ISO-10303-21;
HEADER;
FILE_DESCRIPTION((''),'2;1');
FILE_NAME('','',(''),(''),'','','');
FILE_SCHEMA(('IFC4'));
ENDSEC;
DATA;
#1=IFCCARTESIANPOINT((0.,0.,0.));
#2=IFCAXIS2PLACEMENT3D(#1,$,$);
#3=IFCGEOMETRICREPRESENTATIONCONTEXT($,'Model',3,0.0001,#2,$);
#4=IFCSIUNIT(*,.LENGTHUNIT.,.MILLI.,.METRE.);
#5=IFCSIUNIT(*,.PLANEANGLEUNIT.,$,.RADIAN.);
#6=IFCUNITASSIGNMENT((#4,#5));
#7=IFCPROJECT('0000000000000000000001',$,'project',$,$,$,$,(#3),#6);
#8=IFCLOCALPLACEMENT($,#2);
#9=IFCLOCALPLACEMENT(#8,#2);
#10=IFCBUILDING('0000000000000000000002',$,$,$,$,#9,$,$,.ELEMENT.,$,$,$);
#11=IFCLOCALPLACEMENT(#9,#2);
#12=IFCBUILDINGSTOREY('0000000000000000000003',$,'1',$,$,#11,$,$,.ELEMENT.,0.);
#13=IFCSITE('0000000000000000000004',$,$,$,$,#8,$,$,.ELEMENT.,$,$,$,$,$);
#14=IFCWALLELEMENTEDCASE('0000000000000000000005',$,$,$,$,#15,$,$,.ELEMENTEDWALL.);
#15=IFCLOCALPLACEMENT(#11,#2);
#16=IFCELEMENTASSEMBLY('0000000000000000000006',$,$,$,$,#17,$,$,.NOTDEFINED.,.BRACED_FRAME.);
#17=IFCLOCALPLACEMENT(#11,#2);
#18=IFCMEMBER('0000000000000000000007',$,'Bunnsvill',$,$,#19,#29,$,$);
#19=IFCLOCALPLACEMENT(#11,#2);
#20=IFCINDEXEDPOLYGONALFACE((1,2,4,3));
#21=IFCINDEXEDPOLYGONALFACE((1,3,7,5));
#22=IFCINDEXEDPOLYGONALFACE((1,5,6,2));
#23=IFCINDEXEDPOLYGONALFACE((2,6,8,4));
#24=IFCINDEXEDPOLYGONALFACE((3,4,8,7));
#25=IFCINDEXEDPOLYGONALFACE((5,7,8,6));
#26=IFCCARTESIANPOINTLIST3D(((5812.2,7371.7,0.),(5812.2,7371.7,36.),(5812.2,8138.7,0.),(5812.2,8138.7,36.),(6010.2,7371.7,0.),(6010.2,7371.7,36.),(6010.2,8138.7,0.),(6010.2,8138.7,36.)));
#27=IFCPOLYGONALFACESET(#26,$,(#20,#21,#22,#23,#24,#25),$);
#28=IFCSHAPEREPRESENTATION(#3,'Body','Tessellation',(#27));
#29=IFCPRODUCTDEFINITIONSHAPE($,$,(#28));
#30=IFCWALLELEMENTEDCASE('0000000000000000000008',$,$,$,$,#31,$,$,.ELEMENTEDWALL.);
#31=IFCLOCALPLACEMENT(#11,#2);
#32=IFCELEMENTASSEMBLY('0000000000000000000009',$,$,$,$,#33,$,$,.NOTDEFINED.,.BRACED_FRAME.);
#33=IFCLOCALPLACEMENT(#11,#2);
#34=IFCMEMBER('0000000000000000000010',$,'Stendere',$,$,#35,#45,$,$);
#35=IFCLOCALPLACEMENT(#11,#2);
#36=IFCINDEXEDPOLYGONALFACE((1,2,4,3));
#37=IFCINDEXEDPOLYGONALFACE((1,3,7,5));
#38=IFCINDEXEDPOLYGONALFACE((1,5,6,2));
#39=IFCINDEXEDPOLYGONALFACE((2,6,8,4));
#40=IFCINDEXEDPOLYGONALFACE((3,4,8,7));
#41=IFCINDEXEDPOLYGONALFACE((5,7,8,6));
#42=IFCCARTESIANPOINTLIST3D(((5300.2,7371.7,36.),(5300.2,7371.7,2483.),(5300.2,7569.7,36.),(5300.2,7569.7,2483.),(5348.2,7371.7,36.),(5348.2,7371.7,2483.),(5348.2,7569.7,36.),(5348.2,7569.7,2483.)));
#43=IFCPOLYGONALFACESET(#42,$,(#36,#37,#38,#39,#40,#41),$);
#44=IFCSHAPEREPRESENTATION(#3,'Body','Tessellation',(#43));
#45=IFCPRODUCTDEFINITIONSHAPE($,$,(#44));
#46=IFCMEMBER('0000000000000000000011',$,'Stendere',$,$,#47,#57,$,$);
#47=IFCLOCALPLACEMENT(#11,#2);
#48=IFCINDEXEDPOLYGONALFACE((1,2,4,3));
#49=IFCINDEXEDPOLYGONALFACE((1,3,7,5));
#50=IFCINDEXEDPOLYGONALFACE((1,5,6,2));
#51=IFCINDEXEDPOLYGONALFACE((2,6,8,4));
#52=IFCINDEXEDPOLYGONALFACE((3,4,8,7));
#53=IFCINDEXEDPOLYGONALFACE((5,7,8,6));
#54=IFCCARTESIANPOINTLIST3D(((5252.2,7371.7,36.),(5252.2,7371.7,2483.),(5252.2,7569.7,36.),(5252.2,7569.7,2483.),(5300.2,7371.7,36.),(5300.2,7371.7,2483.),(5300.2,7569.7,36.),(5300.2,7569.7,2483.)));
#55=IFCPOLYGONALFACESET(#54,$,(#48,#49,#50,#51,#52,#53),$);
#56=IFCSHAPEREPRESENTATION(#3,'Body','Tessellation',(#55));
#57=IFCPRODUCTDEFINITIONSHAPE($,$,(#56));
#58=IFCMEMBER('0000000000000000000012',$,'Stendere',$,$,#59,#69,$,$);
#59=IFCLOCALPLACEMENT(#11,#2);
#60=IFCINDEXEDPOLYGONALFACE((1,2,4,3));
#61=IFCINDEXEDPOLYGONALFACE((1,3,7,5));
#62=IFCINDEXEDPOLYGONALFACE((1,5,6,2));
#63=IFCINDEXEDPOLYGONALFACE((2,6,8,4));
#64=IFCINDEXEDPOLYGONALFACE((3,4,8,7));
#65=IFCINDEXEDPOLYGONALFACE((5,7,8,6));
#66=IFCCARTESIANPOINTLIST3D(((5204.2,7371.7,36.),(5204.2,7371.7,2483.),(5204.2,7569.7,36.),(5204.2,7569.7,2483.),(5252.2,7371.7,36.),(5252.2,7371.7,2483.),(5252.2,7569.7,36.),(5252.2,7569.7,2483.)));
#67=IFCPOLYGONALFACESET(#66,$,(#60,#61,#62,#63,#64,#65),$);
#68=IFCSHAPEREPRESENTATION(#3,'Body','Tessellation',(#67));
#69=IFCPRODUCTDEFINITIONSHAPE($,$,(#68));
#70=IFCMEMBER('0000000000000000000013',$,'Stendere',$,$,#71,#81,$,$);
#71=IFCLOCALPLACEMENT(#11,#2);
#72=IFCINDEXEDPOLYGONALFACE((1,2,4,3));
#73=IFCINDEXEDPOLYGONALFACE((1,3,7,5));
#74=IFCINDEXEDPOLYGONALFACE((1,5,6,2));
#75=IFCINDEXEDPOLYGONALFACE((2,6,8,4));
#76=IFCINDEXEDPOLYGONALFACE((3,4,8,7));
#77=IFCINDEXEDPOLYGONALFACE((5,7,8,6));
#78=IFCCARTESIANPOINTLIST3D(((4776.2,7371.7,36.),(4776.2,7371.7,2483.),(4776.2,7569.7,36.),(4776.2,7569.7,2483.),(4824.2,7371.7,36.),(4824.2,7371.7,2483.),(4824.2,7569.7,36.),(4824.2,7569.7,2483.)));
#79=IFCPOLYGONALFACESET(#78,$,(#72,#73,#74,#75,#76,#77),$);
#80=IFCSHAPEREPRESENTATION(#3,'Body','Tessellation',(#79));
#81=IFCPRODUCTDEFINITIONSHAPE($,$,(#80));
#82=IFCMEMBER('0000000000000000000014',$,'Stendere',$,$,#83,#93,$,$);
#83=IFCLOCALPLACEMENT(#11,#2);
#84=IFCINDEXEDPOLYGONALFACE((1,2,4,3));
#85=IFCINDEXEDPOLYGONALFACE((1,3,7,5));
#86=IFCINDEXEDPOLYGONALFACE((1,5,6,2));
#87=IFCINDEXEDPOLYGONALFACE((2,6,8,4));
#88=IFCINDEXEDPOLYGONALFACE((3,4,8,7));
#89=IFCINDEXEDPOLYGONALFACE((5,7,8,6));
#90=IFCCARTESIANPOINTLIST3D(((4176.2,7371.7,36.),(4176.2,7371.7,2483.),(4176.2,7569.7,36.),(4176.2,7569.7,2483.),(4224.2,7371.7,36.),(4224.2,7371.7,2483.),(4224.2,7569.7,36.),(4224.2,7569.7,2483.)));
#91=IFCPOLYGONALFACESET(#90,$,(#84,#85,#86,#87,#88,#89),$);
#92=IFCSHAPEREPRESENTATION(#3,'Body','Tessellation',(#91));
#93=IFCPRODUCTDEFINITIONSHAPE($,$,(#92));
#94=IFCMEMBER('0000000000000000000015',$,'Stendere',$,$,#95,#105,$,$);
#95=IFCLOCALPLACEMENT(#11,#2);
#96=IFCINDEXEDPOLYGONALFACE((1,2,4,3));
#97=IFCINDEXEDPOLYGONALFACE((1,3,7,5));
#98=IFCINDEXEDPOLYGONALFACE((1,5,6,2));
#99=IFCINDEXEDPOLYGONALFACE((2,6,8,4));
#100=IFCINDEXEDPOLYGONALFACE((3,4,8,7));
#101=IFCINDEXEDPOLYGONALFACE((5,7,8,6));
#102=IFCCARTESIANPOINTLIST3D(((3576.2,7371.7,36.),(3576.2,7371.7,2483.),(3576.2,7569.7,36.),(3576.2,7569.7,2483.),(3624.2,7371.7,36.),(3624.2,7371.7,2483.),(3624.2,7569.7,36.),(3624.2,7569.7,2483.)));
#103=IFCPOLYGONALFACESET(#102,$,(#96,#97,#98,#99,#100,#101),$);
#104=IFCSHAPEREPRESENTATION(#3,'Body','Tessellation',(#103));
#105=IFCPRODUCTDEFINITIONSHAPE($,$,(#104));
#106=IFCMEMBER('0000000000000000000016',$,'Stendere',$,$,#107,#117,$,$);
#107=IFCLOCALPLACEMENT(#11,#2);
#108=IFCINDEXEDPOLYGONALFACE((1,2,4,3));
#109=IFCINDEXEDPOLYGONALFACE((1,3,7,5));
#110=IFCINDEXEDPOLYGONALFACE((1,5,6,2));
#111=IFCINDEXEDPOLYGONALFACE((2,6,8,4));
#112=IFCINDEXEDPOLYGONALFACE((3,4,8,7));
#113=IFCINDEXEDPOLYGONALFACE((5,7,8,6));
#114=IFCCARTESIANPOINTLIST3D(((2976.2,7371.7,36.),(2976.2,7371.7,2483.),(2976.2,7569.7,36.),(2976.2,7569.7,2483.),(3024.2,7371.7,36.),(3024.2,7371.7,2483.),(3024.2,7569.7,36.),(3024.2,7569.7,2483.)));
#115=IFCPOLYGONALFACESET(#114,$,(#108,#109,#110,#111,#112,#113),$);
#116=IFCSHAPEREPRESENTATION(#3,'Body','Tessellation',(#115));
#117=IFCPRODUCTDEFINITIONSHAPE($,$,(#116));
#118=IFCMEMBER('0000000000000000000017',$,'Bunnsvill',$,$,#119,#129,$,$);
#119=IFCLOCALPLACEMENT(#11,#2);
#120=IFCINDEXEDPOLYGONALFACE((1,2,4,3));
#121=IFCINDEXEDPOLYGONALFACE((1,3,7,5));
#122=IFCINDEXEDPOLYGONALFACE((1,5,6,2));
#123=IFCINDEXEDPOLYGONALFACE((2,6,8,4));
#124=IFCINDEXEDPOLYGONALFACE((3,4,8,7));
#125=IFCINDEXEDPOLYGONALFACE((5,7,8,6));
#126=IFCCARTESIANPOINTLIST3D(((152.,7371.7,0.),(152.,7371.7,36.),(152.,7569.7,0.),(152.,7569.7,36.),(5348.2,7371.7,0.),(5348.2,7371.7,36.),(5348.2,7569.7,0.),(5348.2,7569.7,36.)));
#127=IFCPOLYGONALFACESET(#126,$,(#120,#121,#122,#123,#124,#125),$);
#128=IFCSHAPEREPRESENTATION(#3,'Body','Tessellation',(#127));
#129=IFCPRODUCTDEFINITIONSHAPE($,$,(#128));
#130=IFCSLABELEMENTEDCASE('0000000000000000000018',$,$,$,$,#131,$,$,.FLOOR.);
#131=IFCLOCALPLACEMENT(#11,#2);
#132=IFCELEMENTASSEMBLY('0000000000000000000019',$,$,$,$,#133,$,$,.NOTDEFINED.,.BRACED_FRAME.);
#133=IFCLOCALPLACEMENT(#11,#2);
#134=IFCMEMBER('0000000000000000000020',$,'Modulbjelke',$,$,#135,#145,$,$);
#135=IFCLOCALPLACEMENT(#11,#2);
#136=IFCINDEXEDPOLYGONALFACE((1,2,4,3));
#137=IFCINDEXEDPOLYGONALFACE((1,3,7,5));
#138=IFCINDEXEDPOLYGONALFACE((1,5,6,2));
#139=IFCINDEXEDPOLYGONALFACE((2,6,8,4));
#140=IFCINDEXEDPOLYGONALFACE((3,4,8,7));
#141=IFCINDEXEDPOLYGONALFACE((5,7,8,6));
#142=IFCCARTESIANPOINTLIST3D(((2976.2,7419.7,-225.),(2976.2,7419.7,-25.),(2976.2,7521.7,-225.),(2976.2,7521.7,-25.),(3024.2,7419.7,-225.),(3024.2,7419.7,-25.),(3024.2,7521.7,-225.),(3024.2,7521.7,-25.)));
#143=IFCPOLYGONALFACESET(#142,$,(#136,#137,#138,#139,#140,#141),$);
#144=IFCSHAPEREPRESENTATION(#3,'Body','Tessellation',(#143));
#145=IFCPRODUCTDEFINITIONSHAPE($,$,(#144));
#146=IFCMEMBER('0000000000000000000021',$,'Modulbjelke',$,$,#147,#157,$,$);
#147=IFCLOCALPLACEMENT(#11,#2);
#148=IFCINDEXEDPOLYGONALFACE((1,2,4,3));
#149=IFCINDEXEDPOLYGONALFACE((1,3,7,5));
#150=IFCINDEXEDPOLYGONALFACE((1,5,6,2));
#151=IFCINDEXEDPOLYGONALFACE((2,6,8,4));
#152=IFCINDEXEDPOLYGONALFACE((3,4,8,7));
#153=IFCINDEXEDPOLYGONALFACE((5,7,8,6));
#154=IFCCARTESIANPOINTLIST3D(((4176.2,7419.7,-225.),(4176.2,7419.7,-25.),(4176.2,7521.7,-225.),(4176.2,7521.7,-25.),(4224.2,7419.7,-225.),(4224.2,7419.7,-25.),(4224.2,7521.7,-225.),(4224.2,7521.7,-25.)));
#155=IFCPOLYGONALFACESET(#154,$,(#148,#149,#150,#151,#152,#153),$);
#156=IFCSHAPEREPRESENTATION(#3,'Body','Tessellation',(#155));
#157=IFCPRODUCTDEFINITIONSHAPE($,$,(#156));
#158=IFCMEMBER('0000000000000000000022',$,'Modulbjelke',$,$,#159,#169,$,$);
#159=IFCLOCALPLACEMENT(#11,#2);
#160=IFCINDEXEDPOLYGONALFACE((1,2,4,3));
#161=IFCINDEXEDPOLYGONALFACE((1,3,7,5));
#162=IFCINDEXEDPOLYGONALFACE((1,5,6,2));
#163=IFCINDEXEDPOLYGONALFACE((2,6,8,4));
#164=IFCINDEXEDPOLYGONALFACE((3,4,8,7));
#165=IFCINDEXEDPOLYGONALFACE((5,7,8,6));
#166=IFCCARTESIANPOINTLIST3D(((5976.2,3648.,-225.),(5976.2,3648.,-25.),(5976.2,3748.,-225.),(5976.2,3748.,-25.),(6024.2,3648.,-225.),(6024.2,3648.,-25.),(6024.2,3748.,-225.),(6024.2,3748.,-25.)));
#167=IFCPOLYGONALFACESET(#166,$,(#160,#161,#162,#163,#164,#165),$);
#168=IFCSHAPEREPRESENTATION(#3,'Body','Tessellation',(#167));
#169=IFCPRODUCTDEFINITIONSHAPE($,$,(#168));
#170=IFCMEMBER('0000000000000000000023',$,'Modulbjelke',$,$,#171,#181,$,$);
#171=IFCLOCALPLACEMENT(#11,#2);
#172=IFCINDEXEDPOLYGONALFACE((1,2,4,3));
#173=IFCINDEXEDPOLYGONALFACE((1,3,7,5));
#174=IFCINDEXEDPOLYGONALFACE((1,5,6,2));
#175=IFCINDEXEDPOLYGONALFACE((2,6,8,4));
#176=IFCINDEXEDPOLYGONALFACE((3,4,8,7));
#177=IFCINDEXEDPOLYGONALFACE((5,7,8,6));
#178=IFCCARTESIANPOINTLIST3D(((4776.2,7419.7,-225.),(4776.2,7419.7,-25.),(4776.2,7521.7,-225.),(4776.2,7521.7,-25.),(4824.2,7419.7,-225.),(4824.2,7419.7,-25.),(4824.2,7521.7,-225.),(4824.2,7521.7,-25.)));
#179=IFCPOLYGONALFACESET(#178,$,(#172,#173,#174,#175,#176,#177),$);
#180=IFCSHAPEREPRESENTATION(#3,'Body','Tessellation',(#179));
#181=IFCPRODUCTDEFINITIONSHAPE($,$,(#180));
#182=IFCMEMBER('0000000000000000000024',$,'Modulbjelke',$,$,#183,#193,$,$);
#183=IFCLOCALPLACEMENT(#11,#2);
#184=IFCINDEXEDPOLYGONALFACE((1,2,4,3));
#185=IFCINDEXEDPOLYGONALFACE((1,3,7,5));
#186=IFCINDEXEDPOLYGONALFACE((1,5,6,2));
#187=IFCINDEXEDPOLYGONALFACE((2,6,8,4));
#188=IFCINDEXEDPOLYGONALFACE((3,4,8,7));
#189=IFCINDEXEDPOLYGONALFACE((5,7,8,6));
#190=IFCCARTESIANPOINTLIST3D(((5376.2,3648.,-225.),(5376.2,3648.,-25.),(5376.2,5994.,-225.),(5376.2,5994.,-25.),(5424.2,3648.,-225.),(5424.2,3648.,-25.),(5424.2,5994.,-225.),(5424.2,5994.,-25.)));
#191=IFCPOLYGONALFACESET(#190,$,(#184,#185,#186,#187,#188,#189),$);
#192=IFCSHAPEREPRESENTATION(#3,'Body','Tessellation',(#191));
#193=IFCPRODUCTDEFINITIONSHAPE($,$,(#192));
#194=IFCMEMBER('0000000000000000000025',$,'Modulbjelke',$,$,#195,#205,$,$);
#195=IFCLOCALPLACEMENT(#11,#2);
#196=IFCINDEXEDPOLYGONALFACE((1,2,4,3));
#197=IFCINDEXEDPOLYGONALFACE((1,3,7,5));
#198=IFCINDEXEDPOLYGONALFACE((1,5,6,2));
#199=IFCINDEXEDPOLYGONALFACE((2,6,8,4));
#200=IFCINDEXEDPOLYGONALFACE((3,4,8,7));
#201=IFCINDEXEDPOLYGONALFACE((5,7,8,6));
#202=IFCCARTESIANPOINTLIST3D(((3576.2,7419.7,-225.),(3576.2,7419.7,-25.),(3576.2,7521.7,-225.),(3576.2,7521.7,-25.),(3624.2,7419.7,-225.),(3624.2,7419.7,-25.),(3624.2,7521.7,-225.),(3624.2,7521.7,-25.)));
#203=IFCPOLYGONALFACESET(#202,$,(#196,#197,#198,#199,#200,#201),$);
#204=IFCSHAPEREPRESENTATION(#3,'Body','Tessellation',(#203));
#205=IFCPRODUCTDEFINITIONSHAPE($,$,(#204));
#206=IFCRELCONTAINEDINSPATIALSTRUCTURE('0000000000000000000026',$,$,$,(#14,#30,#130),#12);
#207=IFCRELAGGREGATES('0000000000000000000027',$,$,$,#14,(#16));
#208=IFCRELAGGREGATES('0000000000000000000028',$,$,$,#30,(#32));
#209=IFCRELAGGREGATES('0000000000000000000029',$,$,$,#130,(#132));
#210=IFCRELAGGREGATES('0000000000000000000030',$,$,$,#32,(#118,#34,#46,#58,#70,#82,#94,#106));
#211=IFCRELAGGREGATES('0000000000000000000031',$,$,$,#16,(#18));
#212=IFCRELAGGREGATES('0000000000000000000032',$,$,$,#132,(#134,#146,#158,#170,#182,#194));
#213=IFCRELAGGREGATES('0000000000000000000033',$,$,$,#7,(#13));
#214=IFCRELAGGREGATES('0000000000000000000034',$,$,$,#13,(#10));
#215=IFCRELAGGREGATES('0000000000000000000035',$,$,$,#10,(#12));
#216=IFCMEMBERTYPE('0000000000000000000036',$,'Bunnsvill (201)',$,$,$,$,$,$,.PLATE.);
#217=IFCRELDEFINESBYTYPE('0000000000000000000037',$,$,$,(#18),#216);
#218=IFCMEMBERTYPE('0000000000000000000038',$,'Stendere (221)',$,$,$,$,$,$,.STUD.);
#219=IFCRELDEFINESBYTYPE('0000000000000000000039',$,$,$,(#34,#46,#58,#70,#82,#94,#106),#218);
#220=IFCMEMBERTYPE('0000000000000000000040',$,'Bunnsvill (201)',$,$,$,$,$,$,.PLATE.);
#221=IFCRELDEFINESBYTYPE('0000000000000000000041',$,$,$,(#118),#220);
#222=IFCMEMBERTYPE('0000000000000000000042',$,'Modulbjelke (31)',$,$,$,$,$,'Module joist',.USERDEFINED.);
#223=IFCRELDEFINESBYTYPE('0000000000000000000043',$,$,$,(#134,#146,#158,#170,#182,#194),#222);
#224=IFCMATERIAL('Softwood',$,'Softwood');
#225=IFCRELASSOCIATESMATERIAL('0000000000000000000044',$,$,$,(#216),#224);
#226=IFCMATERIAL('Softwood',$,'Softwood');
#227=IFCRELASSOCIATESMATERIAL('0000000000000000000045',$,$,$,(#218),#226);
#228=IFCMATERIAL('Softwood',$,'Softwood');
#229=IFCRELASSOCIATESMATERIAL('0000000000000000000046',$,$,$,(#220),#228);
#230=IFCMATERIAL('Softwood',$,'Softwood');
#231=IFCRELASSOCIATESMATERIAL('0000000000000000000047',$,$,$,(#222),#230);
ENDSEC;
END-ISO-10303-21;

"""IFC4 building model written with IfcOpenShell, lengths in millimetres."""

from ifc_helpers import new_model, si_unit, frame, origin, place, context, project, spatial, rectangle, extrude, clip, halfspace, material, material_profile, profile_set, type_object, element, aggregate, save


model = new_model("IFC4")

# Units and contexts
model_context = context("Model", 3, precision=0.0001, world=origin())
ifc_project = project(units=[si_unit("LENGTHUNIT", "METRE", prefix="MILLI"), si_unit("PLANEANGLEUNIT", "RADIAN")], contexts=[model_context])

# Site, building, storey
site_placement = place(None, origin())
site = spatial("IfcSite", under=ifc_project, at=site_placement, CompositionType="ELEMENT")
building_placement = place(site_placement, origin())
building = spatial("IfcBuilding", under=site, at=building_placement, CompositionType="ELEMENT")
storey_placement = place(building_placement, origin())
storey = spatial("IfcBuildingStorey", under=building, at=storey_placement, Name="1", CompositionType="ELEMENT", Elevation=0.0)

# Wall, element assembly, member
wall_1_placement = place(storey_placement, frame((6010.2, 8138.7, 0.0), z_axis=(-1.0, 0.0, 0.0), x_axis=(0.0, -1.0, 0.0)))
wall_1 = element("IfcWallElementedCase", 1, at=wall_1_placement, inside=storey, PredefinedType="ELEMENTEDWALL")
assembly_1_placement = place(wall_1_placement, origin())
assembly_1 = element("IfcElementAssembly", 2, at=assembly_1_placement, AssemblyPlace="NOTDEFINED", PredefinedType="BRACED_FRAME")
aggregate(wall_1, [assembly_1])
ifc_material_1 = material(Name="Softwood", Category="Softwood")
ifc_material_profile_1 = material_profile(ifc_material_1, rectangle(XDim=36.0, YDim=198.0), Name="Bunnsvill (201)")
ifc_profile_set_1 = profile_set([ifc_material_profile_1])
member_type_1 = type_object("IfcMemberType", Name="Bunnsvill (201)", PredefinedType="PLATE", material=ifc_profile_set_1)
member_1_placement = place(assembly_1_placement, frame((0.0, 18.0, 0.0), z_axis=(1.0, 0.0, 0.0), x_axis=(0.0, 1.0, 0.0)))
member_1 = element("IfcMember", 3, at=member_1_placement, type_object=member_type_1, Name="Bunnsvill", context=model_context, shape_type="SweptSolid", body=[
    extrude(rectangle(XDim=36.0, YDim=198.0), frame((0.0, 99.0, 0.0)), (0.0, 0.0, 1.0), 767.0),
])

# Wall, element assembly, members
wall_2_placement = place(storey_placement, frame((5348.2, 7371.7, 0.0), z_axis=(0.0, 1.0, 0.0), x_axis=(-1.0, 0.0, 0.0)))
wall_2 = element("IfcWallElementedCase", 4, at=wall_2_placement, inside=storey, PredefinedType="ELEMENTEDWALL")
assembly_2_placement = place(wall_2_placement, origin())
assembly_2 = element("IfcElementAssembly", 5, at=assembly_2_placement, AssemblyPlace="NOTDEFINED", PredefinedType="BRACED_FRAME")
aggregate(wall_2, [assembly_2])
ifc_material_2 = material(Name="Softwood", Category="Softwood")
ifc_material_profile_2 = material_profile(ifc_material_2, rectangle(XDim=48.0, YDim=198.0), Name="Stendere (221)")
ifc_profile_set_2 = profile_set([ifc_material_profile_2])
member_type_2 = type_object("IfcMemberType", Name="Stendere (221)", PredefinedType="STUD", material=ifc_profile_set_2)
member_2_placement = place(assembly_2_placement, frame((24.0, 36.0, 0.0), z_axis=(0.0, 1.0, 0.0), x_axis=(-1.0, 0.0, 0.0)))
member_2 = element("IfcMember", 6, at=member_2_placement, type_object=member_type_2, Name="Stendere", context=model_context, shape_type="SweptSolid", body=[
    extrude(rectangle(XDim=48.0, YDim=198.0), frame((0.0, 99.0, 0.0)), (0.0, 0.0, 1.0), 2447.0),
])
member_3_placement = place(assembly_2_placement, frame((72.0, 36.0, 0.0), z_axis=(0.0, 1.0, 0.0), x_axis=(-1.0, 0.0, 0.0)))
member_3 = element("IfcMember", 7, at=member_3_placement, type_object=member_type_2, Name="Stendere", context=model_context, shape_type="SweptSolid", body=[
    extrude(rectangle(XDim=48.0, YDim=198.0), frame((0.0, 99.0, 0.0)), (0.0, 0.0, 1.0), 2447.0),
])
member_4_placement = place(assembly_2_placement, frame((120.0, 36.0, 0.0), z_axis=(0.0, 1.0, 0.0), x_axis=(-1.0, 0.0, 0.0)))
member_4 = element("IfcMember", 8, at=member_4_placement, type_object=member_type_2, Name="Stendere", context=model_context, shape_type="SweptSolid", body=[
    extrude(rectangle(XDim=48.0, YDim=198.0), frame((0.0, 99.0, 0.0)), (0.0, 0.0, 1.0), 2447.0),
])
member_5_placement = place(assembly_2_placement, frame((548.0, 36.0, 0.0), z_axis=(0.0, 1.0, 0.0), x_axis=(-1.0, 0.0, 0.0)))
member_5 = element("IfcMember", 9, at=member_5_placement, type_object=member_type_2, Name="Stendere", context=model_context, shape_type="SweptSolid", body=[
    extrude(rectangle(XDim=48.0, YDim=198.0), frame((0.0, 99.0, 0.0)), (0.0, 0.0, 1.0), 2447.0),
])
member_6_placement = place(assembly_2_placement, frame((1148.0, 36.0, 0.0), z_axis=(0.0, 1.0, 0.0), x_axis=(-1.0, 0.0, 0.0)))
member_6 = element("IfcMember", 10, at=member_6_placement, type_object=member_type_2, Name="Stendere", context=model_context, shape_type="SweptSolid", body=[
    extrude(rectangle(XDim=48.0, YDim=198.0), frame((0.0, 99.0, 0.0)), (0.0, 0.0, 1.0), 2447.0),
])
member_7_placement = place(assembly_2_placement, frame((1748.0, 36.0, 0.0), z_axis=(0.0, 1.0, 0.0), x_axis=(-1.0, 0.0, 0.0)))
member_7 = element("IfcMember", 11, at=member_7_placement, type_object=member_type_2, Name="Stendere", context=model_context, shape_type="SweptSolid", body=[
    extrude(rectangle(XDim=48.0, YDim=198.0), frame((0.0, 99.0, 0.0)), (0.0, 0.0, 1.0), 2447.0),
])
member_8_placement = place(assembly_2_placement, frame((2348.0, 36.0, 0.0), z_axis=(0.0, 1.0, 0.0), x_axis=(-1.0, 0.0, 0.0)))
member_8 = element("IfcMember", 12, at=member_8_placement, type_object=member_type_2, Name="Stendere", context=model_context, shape_type="SweptSolid", body=[
    extrude(rectangle(XDim=48.0, YDim=198.0), frame((0.0, 99.0, 0.0)), (0.0, 0.0, 1.0), 2447.0),
])
ifc_material_3 = material(Name="Softwood", Category="Softwood")
ifc_material_profile_3 = material_profile(ifc_material_3, rectangle(XDim=36.0, YDim=198.0), Name="Bunnsvill (201)")
ifc_profile_set_3 = profile_set([ifc_material_profile_3])
member_type_3 = type_object("IfcMemberType", Name="Bunnsvill (201)", PredefinedType="PLATE", material=ifc_profile_set_3)
member_9_placement = place(assembly_2_placement, frame((0.0, 18.0, 0.0), z_axis=(1.0, 0.0, 0.0), x_axis=(0.0, 1.0, 0.0)))
member_9 = element("IfcMember", 13, at=member_9_placement, type_object=member_type_3, Name="Bunnsvill", context=model_context, shape_type="SweptSolid", body=[
    extrude(rectangle(XDim=36.0, YDim=198.0), frame((0.0, 99.0, 0.0)), (0.0, 0.0, 1.0), 5196.2),
])

# Slab, element assembly, members
slab_placement = place(storey_placement, origin())
slab = element("IfcSlabElementedCase", 14, at=slab_placement, inside=storey, PredefinedType="FLOOR")
assembly_3_placement = place(slab_placement, frame((0.0, 0.0, -225.0)))
assembly_3 = element("IfcElementAssembly", 15, at=assembly_3_placement, AssemblyPlace="NOTDEFINED", PredefinedType="BRACED_FRAME")
aggregate(slab, [assembly_3])
ifc_material_4 = material(Name="Softwood", Category="Softwood")
ifc_material_profile_4 = material_profile(ifc_material_4, rectangle(XDim=48.0, YDim=200.0), Name="Modulbjelke (31)")
ifc_profile_set_4 = profile_set([ifc_material_profile_4])
member_type_4 = type_object("IfcMemberType", Name="Modulbjelke (31)", ElementType="Module joist", PredefinedType="USERDEFINED", material=ifc_profile_set_4)
member_10_placement = place(assembly_3_placement, frame((3000.2, 7419.7, 0.0), z_axis=(0.0, 1.0, 0.0), x_axis=(-1.0, 0.0, 0.0)))
member_10 = element("IfcMember", 16, at=member_10_placement, type_object=member_type_4, Name="Modulbjelke", context=model_context, shape_type="SweptSolid", body=[
    extrude(rectangle(XDim=48.0, YDim=200.0), frame((0.0, 100.0, 0.0)), (0.0, 0.0, 1.0), 102.0),
])
member_11_placement = place(assembly_3_placement, frame((4200.2, 7419.7, 0.0), z_axis=(0.0, 1.0, 0.0), x_axis=(-1.0, 0.0, 0.0)))
member_11 = element("IfcMember", 17, at=member_11_placement, type_object=member_type_4, Name="Modulbjelke", context=model_context, shape_type="SweptSolid", body=[
    extrude(rectangle(XDim=48.0, YDim=200.0), frame((0.0, 100.0, 0.0)), (0.0, 0.0, 1.0), 102.0),
])
member_12_placement = place(assembly_3_placement, frame((6000.2, 3648.0, 0.0), z_axis=(0.00001, 1.0, 0.0), x_axis=(-1.0, 0.00001, 0.0)))
member_12 = element("IfcMember", 18, at=member_12_placement, type_object=member_type_4, Name="Modulbjelke", context=model_context, shape_type="Clipping", body=[
    clip(clip(extrude(rectangle(XDim=48.0, YDim=200.0), frame((0.0, 100.0, 0.0)), (0.0, 0.0, 1.0), 100.0), halfspace(frame((0.0, 100.0, 0.0)), True)), halfspace(frame((0.0, 100.0, 100.0)), False)),
])
member_13_placement = place(assembly_3_placement, frame((4800.2, 7419.7, 0.0), z_axis=(0.0, 1.0, 0.0), x_axis=(-1.0, 0.0, 0.0)))
member_13 = element("IfcMember", 19, at=member_13_placement, type_object=member_type_4, Name="Modulbjelke", context=model_context, shape_type="SweptSolid", body=[
    extrude(rectangle(XDim=48.0, YDim=200.0), frame((0.0, 100.0, 0.0)), (0.0, 0.0, 1.0), 102.0),
])
member_14_placement = place(assembly_3_placement, frame((5400.2, 3648.0, 0.0), z_axis=(0.0, 1.0, 0.0), x_axis=(-1.0, 0.0, 0.0)))
member_14 = element("IfcMember", 20, at=member_14_placement, type_object=member_type_4, Name="Modulbjelke", context=model_context, shape_type="SweptSolid", body=[
    extrude(rectangle(XDim=48.0, YDim=200.0), frame((0.0, 100.0, 0.0)), (0.0, 0.0, 1.0), 2346.0),
])
member_15_placement = place(assembly_3_placement, frame((3600.2, 7419.7, 0.0), z_axis=(0.0, 1.0, 0.0), x_axis=(-1.0, 0.0, 0.0)))
member_15 = element("IfcMember", 21, at=member_15_placement, type_object=member_type_4, Name="Modulbjelke", context=model_context, shape_type="SweptSolid", body=[
    extrude(rectangle(XDim=48.0, YDim=200.0), frame((0.0, 100.0, 0.0)), (0.0, 0.0, 1.0), 102.0),
])

aggregate(assembly_2, [member_9, member_2, member_3, member_4, member_5, member_6, member_7, member_8])
aggregate(assembly_1, [member_1])

aggregate(assembly_3, [member_10, member_11, member_12, member_13, member_14, member_15])

save(model, "model.ifc")
